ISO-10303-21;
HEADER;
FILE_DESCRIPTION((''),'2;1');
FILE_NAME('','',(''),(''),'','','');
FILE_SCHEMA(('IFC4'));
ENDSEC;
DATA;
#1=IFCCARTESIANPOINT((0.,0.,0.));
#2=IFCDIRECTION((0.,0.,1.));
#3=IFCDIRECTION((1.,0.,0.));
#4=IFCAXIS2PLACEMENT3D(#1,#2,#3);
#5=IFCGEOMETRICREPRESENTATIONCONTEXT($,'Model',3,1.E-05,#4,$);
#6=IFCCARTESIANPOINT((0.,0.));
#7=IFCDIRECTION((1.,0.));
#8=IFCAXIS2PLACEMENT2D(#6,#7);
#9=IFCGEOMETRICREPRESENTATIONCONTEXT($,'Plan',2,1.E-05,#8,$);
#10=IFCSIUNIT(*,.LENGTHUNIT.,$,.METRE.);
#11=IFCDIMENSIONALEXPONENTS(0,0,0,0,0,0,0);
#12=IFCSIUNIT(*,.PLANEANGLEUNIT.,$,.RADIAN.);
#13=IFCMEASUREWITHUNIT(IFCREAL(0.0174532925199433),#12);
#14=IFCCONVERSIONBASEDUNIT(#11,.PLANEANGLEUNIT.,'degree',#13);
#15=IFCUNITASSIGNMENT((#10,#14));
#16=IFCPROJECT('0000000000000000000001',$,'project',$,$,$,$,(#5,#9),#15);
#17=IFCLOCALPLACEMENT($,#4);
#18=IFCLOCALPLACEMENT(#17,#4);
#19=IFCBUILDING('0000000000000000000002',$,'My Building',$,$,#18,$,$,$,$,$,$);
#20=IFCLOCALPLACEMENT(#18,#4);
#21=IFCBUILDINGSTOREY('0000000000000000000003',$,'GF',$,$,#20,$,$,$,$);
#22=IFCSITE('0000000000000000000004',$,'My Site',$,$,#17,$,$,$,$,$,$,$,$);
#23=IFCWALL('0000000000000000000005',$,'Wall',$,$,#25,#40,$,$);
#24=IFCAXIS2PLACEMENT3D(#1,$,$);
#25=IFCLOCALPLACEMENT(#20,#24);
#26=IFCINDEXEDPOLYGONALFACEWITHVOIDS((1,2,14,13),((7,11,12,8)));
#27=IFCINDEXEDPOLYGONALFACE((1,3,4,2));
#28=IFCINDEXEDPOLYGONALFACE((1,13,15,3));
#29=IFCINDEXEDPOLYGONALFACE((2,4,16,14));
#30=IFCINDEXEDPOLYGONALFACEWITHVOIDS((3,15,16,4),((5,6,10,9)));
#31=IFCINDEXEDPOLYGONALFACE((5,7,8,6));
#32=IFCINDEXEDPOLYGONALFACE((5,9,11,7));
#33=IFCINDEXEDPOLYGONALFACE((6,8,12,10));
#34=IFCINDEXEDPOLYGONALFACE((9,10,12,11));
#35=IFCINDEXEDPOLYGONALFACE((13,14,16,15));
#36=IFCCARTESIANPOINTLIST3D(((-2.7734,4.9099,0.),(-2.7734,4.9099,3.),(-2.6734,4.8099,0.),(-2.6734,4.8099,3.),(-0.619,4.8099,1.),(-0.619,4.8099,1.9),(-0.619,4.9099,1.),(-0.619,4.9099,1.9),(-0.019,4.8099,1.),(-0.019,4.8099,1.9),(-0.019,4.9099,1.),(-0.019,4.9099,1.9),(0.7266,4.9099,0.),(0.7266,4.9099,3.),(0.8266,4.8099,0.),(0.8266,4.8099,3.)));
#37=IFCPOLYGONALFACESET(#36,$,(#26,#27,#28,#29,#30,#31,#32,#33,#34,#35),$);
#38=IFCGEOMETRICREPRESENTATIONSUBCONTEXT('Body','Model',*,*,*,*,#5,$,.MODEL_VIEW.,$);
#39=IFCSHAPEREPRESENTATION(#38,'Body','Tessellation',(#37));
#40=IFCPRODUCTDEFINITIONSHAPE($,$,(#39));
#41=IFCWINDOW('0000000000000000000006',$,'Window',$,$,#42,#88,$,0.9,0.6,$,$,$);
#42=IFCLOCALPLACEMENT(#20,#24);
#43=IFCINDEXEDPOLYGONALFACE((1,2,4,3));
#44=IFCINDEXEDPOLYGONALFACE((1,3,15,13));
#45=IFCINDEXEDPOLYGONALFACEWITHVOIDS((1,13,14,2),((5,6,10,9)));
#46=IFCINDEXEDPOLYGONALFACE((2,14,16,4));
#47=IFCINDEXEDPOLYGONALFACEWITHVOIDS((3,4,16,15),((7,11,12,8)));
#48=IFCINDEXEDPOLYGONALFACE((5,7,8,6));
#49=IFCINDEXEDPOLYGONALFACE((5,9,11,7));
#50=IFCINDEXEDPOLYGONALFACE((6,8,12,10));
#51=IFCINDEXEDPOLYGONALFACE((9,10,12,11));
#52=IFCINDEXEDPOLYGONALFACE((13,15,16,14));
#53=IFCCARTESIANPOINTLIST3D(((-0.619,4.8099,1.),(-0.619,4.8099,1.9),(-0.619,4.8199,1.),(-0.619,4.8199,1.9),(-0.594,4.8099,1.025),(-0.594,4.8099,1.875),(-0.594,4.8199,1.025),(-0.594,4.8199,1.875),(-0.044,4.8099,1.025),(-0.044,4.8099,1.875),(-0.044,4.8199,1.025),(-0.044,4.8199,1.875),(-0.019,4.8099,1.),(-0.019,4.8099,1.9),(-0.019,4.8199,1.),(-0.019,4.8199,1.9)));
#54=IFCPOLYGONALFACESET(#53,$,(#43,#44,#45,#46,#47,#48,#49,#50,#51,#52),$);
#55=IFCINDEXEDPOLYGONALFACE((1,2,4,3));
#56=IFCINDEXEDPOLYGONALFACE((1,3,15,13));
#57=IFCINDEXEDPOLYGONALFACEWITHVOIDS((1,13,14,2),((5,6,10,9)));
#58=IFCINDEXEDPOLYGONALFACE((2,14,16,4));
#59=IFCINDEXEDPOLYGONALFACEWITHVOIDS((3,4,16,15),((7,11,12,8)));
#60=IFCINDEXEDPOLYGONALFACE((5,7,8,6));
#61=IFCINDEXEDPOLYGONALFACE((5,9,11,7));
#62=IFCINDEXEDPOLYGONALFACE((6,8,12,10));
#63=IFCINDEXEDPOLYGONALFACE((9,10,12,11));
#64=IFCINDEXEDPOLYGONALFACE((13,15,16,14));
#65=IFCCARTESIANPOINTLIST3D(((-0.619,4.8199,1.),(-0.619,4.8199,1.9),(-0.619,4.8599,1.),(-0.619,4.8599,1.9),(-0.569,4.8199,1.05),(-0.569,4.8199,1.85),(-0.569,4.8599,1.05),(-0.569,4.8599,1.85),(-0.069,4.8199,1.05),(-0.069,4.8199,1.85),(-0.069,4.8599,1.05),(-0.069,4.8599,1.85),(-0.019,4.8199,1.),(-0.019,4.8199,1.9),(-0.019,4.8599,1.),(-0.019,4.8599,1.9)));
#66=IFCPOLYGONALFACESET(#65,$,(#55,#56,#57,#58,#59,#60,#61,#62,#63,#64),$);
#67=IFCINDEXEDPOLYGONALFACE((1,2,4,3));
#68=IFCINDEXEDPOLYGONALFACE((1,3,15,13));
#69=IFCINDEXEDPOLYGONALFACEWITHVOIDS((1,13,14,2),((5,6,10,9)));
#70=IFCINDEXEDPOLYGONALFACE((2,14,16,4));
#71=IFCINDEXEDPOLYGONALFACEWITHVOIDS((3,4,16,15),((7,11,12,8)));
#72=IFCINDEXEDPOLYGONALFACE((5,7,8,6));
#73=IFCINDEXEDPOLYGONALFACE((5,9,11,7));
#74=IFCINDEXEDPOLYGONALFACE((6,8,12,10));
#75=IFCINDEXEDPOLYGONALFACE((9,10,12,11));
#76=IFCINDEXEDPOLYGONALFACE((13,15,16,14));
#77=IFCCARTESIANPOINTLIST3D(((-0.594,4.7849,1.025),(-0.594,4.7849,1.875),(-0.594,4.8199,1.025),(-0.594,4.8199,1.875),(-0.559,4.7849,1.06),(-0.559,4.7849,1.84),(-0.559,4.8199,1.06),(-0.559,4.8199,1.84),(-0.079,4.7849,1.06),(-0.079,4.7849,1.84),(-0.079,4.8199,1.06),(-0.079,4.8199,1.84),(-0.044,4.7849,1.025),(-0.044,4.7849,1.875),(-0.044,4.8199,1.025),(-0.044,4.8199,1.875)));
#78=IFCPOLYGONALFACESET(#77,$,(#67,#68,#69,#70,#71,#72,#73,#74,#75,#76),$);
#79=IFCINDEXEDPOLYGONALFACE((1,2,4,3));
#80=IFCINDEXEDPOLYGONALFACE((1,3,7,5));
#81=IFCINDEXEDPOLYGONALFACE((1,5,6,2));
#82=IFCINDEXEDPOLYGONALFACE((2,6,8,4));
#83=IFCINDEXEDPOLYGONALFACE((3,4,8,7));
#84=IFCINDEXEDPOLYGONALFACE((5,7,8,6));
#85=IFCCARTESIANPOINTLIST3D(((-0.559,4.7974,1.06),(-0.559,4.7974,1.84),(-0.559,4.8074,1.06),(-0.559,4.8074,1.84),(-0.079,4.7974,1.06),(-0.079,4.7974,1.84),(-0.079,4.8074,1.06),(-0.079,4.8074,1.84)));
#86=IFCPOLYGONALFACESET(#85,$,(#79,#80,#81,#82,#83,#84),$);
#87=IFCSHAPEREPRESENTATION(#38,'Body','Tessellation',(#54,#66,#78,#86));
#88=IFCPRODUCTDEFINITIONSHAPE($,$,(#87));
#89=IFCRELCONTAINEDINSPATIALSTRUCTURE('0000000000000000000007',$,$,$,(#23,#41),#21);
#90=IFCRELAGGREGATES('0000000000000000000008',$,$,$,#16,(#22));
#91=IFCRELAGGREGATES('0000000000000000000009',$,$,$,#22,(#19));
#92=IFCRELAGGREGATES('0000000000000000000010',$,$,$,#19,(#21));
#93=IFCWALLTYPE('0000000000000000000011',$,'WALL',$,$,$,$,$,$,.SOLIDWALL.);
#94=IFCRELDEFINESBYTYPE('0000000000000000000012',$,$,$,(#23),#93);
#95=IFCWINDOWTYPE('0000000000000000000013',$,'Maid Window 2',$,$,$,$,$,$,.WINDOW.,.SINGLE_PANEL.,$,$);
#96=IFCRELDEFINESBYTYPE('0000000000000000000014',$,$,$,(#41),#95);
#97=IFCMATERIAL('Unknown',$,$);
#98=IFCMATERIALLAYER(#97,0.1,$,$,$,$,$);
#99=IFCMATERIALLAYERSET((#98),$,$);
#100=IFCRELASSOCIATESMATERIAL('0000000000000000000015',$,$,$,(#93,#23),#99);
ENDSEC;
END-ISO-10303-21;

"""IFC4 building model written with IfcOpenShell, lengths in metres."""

from ifc_helpers import new_model, entity, si_unit, converted_unit, frame, origin_with_axes, origin_2d_with_axis, place, context, subcontext, project, spatial, line, indexed_curve, outline, extrude, shape, source, transform, mapped, material, layer, layer_set, layer_usage, type_object, type_shapes, element, fill, save


model = new_model("IFC4")

# Units and contexts
model_context = context("Model", 3, precision=1e-05, world=origin_with_axes())
plan_context = context("Plan", 2, precision=1e-05, world=origin_2d_with_axis())
body_context_1 = subcontext(model_context, "Body", "Model", "MODEL_VIEW")
body_context_2 = subcontext(plan_context, "Body", "Plan", "PLAN_VIEW")
ifc_project = project(units=[si_unit("LENGTHUNIT", "METRE"), converted_unit("PLANEANGLEUNIT", "degree", entity("IfcReal", 0.0174532925199433), si_unit("PLANEANGLEUNIT", "RADIAN"), dimensions=[0, 0, 0, 0, 0, 0, 0])], contexts=[model_context, plan_context])

# Site, building, storey
site_placement = place(None, origin_with_axes())
site = spatial("IfcSite", under=ifc_project, at=site_placement, Name="My Site")
building_placement = place(site_placement, origin_with_axes())
building = spatial("IfcBuilding", under=site, at=building_placement, Name="My Building")
storey_placement = place(building_placement, origin_with_axes())
storey = spatial("IfcBuildingStorey", under=building, at=storey_placement, Name="GF")

# Shared definitions
ifc_material_1 = material(Name="Unknown")

# Shared definitions
ifc_layer_1 = layer(ifc_material_1, 0.1)
ifc_layer_set_1 = layer_set([ifc_layer_1])
wall_type = type_object("IfcWallType", Name="WALL", PredefinedType="SOLIDWALL", material=ifc_layer_set_1)

# Wall, opening, window
ifc_layer_usage_1 = layer_usage(ifc_layer_set_1, "AXIS2", "POSITIVE", 0.0)
wall_1_placement = place(storey_placement, frame((0.7266, 4.9099, 0.0), z_axis=(0.0, 0.0, 1.0), x_axis=(-1.0, 0.0, 0.0)))
wall_1 = element("IfcWall", 1, at=wall_1_placement, inside=storey, type_object=wall_type, material=ifc_layer_usage_1, Name="Wall", context=body_context_1, shape_type="SweptSolid", body=[
    extrude(outline(indexed_curve([(0.0, 0.0), (-0.1, 0.1), (3.4, 0.1), (3.5, 0.0)], segments=[line(1, 2, 3, 4, 1)])), origin_with_axes(), (0.0, 0.0, 1.0), 3.0),
])
shared_shape_1 = source(origin_with_axes(), body_context_1, "Body", "SweptSolid", [
    extrude(outline(indexed_curve([(0.0, 0.0), (0.6, 0.0), (0.6, 0.9), (0.0, 0.9)], segments=[line(1, 2, 3, 4, 1)])), frame((0.0, -0.6, 0.0), z_axis=(0.0, -1.0, 0.0), x_axis=(1.0, 0.0, 0.0)), (0.0, 0.0, -1.0), 1.2),
])
opening_1_placement = place(wall_1_placement, frame((0.7456, 0.0, 1.0), z_axis=(0.0, 0.0, 1.0), x_axis=(1.0, 0.0, 0.0)))
opening_1 = element("IfcOpeningElement", 2, at=opening_1_placement, cuts=wall_1, PredefinedType="OPENING", context=body_context_1, shape_type="MappedRepresentation", body=[
    mapped(shared_shape_1, transform((0.0, 0.0, 0.0), x_axis=(1.0, 0.0, 0.0), y_axis=(0.0, 1.0, 0.0), z_axis=(0.0, 0.0, 1.0), scale=1.0)),
])
window_type_1 = type_object("IfcWindowType", Name="Maid Window 2", PartitioningType="SINGLE_PANEL", PredefinedType="WINDOW")
shared_shape_2 = source(origin_with_axes(), body_context_1, "Body", "SweptSolid", [
    extrude(outline(indexed_curve([(0.0, 0.0), (0.6, 0.0), (0.6, 0.9), (0.0, 0.9)], segments=[line(1, 2, 3, 4, 1)]), holes=[indexed_curve([(0.025, 0.025), (0.575, 0.025), (0.575, 0.875), (0.025, 0.875)], segments=[line(1, 2, 3, 4, 1)])]), frame((0.0, 0.09, 0.0), z_axis=(0.0, -1.0, 0.0), x_axis=(1.0, 0.0, 0.0)), (0.0, 0.0, -1.0), 0.01),
    extrude(outline(indexed_curve([(0.0, 0.0), (0.6, 0.0), (0.6, 0.9), (0.0, 0.9)], segments=[line(1, 2, 3, 4, 1)]), holes=[indexed_curve([(0.05, 0.05), (0.55, 0.05), (0.55, 0.85), (0.05, 0.85)], segments=[line(1, 2, 3, 4, 1)])]), frame((0.0, 0.05, 0.0), z_axis=(0.0, -1.0, 0.0), x_axis=(1.0, 0.0, 0.0)), (0.0, 0.0, -1.0), 0.04),
    extrude(outline(indexed_curve([(0.0, 0.0), (0.55, 0.0), (0.55, 0.85), (0.0, 0.85)], segments=[line(1, 2, 3, 4, 1)]), holes=[indexed_curve([(0.035, 0.035), (0.515, 0.035), (0.515, 0.815), (0.035, 0.815)], segments=[line(1, 2, 3, 4, 1)])]), frame((0.025, 0.09, 0.025), z_axis=(0.0, -1.0, 0.0), x_axis=(1.0, 0.0, 0.0)), (0.0, 0.0, -1.0), 0.035),
    extrude(outline(indexed_curve([(0.035, 0.035), (0.515, 0.035), (0.515, 0.815), (0.035, 0.815)], segments=[line(1, 2, 3, 4, 1)])), frame((0.025, 0.1025, 0.025), z_axis=(0.0, -1.0, 0.0), x_axis=(1.0, 0.0, 0.0)), (0.0, 0.0, -1.0), 0.01),
])
shared_shape_3 = source(origin_with_axes(), body_context_2, "Body", "Curve2D", [
    entity("IfcIndexedPolyCurve", entity("IfcCartesianPointList2D", [[0.05, 0.05], [0.55, 0.05]])),
    entity("IfcIndexedPolyCurve", entity("IfcCartesianPointList2D", [[0.0, 0.1], [0.025, 0.1], [0.025, 0.09], [0.05, 0.09], [0.05, 0.05], [0.0, 0.05]]), [entity("IfcLineIndex", [1, 2, 3, 4, 5, 6, 1])]),
    entity("IfcIndexedPolyCurve", entity("IfcCartesianPointList2D", [[0.6, 0.1], [0.575, 0.1], [0.575, 0.09], [0.55, 0.09], [0.55, 0.05], [0.6, 0.05]]), [entity("IfcLineIndex", [1, 2, 3, 4, 5, 6, 1])]),
    entity("IfcIndexedPolyCurve", entity("IfcCartesianPointList2D", [[0.025, 0.09], [0.06, 0.09], [0.06, 0.125], [0.025, 0.125]]), [entity("IfcLineIndex", [1, 2, 3, 4, 1])]),
    entity("IfcIndexedPolyCurve", entity("IfcCartesianPointList2D", [[0.575, 0.09], [0.54, 0.09], [0.54, 0.125], [0.575, 0.125]]), [entity("IfcLineIndex", [1, 2, 3, 4, 1])]),
    entity("IfcIndexedPolyCurve", entity("IfcCartesianPointList2D", [[0.06, 0.09], [0.54, 0.09]])),
    entity("IfcIndexedPolyCurve", entity("IfcCartesianPointList2D", [[0.06, 0.125], [0.54, 0.125]])),
    entity("IfcIndexedPolyCurve", entity("IfcCartesianPointList2D", [[0.06, 0.1075], [0.54, 0.1075]])),
])
type_shapes(window_type_1, [shared_shape_2, shared_shape_3])
window_1_placement = place(opening_1_placement, frame((0.0, 0.0, 0.0), z_axis=(0.0, 0.0, 1.0), x_axis=(1.0, 0.0, 0.0)))
window_1 = element("IfcWindow", 3, at=window_1_placement, inside=storey, type_object=window_type_1, Name="Window", OverallHeight=0.9, OverallWidth=0.6, shapes=[
    shape(body_context_1, "Body", "MappedRepresentation", [mapped(shared_shape_2, transform((0.0, 0.0, 0.0), x_axis=(1.0, 0.0, 0.0), y_axis=(0.0, 1.0, 0.0), z_axis=(0.0, 0.0, 1.0), scale=1.0))]),
    shape(body_context_2, "Body", "MappedRepresentation", [mapped(shared_shape_3, transform((0.0, 0.0, 0.0), x_axis=(1.0, 0.0, 0.0), y_axis=(0.0, 1.0, 0.0), z_axis=(0.0, 0.0, 1.0), scale=1.0))]),
])
fill(opening_1, window_1)

save(model, "model.ifc")
